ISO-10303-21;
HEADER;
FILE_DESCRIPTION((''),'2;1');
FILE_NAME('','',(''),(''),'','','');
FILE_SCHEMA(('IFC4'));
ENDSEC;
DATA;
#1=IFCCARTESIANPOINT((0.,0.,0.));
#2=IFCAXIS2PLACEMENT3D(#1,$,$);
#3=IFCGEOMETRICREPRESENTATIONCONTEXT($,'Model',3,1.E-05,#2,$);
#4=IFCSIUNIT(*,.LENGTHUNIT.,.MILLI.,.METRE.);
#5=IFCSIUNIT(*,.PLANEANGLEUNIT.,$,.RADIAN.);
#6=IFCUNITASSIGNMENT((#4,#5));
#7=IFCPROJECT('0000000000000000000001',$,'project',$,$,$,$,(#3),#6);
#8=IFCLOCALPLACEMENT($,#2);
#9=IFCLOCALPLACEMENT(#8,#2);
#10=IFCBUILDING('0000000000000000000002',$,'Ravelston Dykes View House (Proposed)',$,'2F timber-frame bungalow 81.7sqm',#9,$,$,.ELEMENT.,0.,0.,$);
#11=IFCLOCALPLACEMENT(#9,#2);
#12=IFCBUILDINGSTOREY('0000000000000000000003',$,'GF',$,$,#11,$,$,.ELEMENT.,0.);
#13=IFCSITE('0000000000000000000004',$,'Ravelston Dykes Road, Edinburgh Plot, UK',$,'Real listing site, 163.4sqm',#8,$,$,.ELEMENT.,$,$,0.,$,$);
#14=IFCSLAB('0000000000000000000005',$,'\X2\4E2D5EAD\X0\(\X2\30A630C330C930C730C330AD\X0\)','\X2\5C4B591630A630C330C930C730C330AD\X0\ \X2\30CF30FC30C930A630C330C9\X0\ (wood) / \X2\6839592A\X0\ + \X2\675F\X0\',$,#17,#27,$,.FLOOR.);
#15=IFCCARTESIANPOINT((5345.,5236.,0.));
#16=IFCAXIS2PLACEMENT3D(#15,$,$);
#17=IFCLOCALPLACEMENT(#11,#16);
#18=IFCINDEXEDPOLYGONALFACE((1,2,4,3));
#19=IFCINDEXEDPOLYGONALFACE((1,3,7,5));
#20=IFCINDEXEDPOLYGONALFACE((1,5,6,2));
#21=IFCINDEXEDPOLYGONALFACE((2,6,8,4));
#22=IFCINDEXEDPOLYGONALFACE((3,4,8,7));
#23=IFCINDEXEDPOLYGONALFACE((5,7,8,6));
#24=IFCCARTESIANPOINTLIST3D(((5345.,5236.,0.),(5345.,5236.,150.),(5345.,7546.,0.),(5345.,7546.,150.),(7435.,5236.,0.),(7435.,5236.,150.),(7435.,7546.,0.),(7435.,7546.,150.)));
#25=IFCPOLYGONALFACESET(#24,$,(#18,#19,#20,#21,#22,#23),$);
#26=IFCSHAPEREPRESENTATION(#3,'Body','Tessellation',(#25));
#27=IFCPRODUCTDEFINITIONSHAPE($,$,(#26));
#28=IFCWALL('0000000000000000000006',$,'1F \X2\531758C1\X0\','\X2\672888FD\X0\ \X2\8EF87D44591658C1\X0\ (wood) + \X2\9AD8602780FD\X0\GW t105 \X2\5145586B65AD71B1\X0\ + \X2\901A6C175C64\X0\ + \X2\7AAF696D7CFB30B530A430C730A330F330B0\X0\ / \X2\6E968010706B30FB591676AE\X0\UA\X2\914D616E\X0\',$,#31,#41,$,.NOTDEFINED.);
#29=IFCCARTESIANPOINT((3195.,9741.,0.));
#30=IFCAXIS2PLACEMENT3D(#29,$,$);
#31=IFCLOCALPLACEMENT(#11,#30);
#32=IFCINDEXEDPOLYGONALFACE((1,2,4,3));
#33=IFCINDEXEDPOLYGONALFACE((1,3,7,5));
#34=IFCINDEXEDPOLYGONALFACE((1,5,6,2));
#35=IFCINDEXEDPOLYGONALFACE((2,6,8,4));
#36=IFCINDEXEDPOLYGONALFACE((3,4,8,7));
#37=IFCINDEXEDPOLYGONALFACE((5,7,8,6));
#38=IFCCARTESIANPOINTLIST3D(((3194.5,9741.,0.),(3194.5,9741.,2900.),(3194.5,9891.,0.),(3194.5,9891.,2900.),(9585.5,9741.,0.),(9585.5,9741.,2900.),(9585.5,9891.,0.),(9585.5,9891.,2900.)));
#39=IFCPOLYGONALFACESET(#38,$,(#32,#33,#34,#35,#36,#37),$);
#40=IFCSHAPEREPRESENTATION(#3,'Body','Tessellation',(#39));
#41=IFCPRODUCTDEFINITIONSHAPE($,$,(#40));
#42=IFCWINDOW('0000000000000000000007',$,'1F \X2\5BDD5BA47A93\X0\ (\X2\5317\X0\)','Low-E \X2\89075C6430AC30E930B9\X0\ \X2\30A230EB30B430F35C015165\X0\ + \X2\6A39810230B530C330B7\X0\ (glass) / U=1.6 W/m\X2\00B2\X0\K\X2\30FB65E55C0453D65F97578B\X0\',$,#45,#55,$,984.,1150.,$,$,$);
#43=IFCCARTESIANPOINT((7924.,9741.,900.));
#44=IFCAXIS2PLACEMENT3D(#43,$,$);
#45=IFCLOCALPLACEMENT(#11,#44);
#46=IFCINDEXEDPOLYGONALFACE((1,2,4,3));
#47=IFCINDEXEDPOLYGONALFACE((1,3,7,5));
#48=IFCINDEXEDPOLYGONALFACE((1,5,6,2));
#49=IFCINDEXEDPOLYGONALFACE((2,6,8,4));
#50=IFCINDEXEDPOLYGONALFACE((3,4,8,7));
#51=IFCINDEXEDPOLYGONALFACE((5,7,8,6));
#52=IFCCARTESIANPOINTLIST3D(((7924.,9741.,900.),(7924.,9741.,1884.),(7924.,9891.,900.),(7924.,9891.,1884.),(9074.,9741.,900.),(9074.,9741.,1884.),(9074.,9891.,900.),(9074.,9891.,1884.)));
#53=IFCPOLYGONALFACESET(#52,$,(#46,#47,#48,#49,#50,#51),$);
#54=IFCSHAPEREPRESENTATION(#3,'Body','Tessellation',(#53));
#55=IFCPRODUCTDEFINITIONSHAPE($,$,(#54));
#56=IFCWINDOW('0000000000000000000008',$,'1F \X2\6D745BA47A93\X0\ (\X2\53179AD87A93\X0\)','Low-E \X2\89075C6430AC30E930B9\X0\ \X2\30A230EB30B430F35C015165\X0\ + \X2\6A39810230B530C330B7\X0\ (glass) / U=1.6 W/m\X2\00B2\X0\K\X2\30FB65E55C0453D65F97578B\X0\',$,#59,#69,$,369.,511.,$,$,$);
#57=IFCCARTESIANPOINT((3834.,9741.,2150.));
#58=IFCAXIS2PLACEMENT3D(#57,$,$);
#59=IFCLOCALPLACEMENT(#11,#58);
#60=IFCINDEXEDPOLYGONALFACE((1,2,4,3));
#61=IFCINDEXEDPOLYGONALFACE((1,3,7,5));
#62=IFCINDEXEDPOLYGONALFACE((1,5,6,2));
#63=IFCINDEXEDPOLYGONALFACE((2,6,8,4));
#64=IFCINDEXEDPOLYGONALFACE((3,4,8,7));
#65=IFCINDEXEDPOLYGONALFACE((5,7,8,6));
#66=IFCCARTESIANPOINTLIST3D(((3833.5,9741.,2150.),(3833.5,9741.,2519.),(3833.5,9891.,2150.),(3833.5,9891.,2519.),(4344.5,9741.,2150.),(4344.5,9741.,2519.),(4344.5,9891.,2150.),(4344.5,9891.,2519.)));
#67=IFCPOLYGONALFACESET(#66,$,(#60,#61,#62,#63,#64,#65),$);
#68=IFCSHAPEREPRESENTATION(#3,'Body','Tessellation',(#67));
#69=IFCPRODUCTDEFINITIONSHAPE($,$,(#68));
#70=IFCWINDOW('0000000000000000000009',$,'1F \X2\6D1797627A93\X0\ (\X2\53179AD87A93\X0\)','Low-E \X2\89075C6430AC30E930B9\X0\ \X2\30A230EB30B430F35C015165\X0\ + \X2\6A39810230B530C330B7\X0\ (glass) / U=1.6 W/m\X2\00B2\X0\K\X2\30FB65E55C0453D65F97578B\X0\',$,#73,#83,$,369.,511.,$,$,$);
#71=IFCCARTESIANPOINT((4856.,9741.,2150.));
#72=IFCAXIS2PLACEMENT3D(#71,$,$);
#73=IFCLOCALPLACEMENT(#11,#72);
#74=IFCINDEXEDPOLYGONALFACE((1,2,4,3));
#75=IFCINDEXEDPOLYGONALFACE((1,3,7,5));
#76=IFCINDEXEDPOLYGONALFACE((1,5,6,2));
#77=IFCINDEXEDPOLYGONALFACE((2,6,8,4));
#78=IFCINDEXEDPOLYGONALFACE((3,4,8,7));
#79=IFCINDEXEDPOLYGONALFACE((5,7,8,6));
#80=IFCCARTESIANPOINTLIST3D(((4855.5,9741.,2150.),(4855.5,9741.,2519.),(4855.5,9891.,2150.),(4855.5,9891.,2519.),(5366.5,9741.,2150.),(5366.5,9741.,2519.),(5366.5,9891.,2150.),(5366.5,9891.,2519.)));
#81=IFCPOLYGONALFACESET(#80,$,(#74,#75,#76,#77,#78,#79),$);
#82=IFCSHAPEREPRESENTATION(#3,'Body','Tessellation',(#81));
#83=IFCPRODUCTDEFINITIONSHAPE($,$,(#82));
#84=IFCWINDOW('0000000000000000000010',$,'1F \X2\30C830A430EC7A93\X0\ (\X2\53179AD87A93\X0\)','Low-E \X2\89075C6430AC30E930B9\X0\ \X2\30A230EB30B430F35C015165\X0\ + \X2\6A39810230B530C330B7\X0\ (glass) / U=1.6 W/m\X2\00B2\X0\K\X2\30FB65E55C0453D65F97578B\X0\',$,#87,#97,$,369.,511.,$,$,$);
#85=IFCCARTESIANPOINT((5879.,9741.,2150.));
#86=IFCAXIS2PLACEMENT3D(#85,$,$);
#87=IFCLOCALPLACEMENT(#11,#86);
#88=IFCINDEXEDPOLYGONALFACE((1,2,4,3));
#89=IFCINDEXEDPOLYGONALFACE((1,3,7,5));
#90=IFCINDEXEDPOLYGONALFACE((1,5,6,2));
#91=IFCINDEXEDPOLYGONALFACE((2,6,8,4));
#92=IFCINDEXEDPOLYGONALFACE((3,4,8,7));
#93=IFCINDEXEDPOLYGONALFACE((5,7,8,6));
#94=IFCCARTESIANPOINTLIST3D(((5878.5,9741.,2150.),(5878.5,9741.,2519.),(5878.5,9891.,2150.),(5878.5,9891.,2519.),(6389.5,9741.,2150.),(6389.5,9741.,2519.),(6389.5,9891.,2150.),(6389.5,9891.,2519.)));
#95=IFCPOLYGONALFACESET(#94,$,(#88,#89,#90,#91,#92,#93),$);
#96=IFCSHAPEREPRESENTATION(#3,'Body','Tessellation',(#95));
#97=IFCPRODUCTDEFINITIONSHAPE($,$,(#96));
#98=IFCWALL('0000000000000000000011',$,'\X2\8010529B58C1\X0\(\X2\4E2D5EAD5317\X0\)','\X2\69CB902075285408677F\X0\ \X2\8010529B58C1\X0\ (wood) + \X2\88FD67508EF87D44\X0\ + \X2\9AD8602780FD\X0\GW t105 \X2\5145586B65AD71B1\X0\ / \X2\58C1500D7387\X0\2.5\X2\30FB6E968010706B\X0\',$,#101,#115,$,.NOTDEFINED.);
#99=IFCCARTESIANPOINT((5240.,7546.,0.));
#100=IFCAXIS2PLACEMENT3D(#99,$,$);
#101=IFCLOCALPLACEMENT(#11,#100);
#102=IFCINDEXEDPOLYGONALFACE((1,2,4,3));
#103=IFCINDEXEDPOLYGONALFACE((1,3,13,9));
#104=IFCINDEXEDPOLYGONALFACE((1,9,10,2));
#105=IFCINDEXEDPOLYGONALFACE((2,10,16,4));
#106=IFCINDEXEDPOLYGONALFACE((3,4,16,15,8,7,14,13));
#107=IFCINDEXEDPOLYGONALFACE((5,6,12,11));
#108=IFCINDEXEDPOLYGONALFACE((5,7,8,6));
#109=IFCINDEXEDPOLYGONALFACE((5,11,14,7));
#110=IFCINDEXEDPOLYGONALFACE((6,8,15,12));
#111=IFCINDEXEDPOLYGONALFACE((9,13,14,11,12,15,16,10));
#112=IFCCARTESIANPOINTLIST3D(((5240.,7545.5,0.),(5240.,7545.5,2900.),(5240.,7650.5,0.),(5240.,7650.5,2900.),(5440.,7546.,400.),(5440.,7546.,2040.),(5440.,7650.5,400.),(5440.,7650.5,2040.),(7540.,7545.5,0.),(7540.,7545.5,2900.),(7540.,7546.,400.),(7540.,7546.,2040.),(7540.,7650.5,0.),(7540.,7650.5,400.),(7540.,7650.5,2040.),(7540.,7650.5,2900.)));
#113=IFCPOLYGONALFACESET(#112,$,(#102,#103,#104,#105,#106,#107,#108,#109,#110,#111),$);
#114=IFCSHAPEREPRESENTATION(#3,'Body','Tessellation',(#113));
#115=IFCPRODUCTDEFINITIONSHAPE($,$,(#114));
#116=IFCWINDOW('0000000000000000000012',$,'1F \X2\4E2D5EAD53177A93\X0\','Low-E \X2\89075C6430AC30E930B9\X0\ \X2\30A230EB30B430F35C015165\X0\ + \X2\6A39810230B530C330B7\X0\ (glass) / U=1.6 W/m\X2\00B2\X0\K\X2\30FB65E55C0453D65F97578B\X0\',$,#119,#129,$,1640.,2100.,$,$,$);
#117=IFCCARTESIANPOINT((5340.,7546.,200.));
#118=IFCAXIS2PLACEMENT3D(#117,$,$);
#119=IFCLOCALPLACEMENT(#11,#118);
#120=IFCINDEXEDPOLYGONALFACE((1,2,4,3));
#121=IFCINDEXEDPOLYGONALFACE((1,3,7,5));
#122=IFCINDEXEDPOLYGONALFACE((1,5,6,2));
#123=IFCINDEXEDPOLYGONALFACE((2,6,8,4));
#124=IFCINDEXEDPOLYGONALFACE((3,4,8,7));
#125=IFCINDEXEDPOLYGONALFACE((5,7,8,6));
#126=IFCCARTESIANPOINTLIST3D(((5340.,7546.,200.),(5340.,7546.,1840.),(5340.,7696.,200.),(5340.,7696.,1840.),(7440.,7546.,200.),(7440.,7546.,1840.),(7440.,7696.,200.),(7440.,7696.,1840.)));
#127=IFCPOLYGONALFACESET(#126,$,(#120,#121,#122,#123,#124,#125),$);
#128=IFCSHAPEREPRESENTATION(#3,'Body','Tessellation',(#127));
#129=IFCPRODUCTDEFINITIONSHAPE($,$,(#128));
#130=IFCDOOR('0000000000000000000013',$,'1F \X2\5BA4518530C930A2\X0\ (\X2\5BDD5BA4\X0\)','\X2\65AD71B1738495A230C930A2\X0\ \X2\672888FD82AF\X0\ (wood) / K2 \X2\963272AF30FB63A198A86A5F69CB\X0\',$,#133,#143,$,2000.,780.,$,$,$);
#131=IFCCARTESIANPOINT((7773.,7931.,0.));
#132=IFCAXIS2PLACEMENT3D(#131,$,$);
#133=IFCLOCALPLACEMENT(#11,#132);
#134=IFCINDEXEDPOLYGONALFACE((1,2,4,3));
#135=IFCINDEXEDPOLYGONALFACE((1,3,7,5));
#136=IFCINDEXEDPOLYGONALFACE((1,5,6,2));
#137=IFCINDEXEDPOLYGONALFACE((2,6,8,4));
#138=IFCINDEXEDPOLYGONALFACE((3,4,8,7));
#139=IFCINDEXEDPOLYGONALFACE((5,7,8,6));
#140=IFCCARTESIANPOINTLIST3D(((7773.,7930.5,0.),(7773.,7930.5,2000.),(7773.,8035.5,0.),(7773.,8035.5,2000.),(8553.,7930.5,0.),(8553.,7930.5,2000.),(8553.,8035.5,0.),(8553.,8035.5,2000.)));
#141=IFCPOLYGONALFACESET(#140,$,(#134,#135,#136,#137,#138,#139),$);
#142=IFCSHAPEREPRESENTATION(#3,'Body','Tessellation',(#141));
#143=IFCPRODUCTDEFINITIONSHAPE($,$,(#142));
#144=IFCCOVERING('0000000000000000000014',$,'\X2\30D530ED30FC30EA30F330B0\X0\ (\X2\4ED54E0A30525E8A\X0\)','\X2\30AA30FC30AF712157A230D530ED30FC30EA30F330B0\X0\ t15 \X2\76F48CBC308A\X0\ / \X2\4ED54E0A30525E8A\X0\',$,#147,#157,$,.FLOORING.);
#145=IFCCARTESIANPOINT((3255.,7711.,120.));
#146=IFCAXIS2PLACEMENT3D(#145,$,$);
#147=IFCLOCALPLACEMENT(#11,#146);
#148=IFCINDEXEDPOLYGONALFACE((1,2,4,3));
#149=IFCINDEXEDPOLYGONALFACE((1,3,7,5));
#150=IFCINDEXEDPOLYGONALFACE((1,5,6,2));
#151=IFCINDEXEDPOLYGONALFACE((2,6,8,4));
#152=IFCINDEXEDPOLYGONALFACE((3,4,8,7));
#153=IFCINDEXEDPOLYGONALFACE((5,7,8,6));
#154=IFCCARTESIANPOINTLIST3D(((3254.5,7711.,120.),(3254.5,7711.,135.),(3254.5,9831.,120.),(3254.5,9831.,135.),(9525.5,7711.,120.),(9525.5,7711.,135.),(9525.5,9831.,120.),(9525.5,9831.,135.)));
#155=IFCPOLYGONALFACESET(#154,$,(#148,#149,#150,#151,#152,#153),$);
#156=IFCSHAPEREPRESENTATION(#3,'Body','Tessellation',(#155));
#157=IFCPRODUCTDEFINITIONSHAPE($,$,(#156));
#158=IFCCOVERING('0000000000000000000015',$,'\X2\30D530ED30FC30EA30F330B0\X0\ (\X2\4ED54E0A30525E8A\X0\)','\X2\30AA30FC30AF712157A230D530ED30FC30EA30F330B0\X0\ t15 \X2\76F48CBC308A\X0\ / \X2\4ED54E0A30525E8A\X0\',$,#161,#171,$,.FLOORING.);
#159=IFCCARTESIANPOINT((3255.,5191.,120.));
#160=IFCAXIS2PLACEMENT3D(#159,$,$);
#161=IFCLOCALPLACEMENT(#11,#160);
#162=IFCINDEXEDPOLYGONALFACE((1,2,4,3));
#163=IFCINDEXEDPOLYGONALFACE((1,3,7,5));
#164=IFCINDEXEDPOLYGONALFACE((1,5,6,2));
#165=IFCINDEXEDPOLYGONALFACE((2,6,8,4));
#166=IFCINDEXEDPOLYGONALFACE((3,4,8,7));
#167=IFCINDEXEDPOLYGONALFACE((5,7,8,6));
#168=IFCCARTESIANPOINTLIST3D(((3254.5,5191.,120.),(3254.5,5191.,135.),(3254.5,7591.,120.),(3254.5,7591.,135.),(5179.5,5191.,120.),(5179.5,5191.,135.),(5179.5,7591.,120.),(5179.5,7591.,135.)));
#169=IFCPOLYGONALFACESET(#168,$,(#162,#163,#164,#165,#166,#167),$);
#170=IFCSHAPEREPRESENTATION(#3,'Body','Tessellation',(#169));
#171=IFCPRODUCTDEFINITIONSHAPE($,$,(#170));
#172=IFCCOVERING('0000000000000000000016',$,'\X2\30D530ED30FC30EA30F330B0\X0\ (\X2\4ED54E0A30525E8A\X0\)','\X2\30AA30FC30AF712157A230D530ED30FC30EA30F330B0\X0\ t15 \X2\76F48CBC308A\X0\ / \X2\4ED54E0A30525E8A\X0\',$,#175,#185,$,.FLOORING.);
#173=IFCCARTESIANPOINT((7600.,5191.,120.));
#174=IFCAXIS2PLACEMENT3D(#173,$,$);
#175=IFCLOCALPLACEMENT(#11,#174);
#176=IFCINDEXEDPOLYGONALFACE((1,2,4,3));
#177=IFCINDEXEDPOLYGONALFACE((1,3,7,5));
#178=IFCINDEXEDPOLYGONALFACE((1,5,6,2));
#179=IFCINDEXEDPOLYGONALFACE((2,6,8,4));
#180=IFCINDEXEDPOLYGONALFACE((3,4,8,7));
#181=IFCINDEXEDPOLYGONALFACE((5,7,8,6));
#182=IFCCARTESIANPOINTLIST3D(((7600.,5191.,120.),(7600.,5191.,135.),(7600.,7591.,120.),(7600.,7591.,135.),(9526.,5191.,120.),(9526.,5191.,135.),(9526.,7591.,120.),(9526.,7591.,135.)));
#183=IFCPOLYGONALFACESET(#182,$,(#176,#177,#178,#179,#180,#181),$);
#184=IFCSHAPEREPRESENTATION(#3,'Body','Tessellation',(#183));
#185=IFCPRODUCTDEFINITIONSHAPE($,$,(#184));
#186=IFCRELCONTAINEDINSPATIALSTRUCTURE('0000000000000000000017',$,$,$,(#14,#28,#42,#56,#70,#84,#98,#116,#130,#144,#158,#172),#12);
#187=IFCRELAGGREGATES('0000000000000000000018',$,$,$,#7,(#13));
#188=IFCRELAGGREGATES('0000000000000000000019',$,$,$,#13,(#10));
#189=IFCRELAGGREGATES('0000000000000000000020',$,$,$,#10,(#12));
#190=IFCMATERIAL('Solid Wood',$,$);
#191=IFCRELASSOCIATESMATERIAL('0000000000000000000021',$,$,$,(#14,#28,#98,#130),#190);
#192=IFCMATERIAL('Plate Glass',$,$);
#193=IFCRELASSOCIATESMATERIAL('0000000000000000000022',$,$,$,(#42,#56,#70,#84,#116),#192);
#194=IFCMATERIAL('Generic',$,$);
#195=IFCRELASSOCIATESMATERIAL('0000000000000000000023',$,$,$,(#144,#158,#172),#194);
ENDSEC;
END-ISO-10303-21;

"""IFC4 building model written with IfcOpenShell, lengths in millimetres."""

from ifc_helpers import new_model, si_unit, frame, frame_2d, origin, place, context, project, spatial, rectangle, extrude, material, element, fill, save


model = new_model("IFC4")

# Units and contexts
model_context = context("Model", 3, precision=1e-05, world=origin())
ifc_project = project(units=[si_unit("LENGTHUNIT", "METRE", prefix="MILLI"), si_unit("PLANEANGLEUNIT", "RADIAN")], contexts=[model_context])

# Site, building, storey
site_placement = place(None, origin())
site = spatial("IfcSite", under=ifc_project, at=site_placement, Name="Ravelston Dykes Road, Edinburgh Plot, UK", ObjectType="Real listing site, 163.4sqm", CompositionType="ELEMENT", RefElevation=0.0)
building_placement = place(site_placement, origin())
building = spatial("IfcBuilding", under=site, at=building_placement, Name="Ravelston Dykes View House (Proposed)", ObjectType="2F timber-frame bungalow 81.7sqm", CompositionType="ELEMENT", ElevationOfRefHeight=0.0, ElevationOfTerrain=0.0)
storey_placement = place(building_placement, origin())
storey = spatial("IfcBuildingStorey", under=building, at=storey_placement, Name="GF", CompositionType="ELEMENT", Elevation=0.0)

# Slab
ifc_material_1 = material(Name="Solid Wood")
slab_1_placement = place(storey_placement, frame((5345.0, 5236.0, 0.0)))
element("IfcSlab", 1, at=slab_1_placement, inside=storey, material=ifc_material_1, Name="中庭(ウッドデッキ)", Description="屋外ウッドデッキ ハードウッド (wood) / 根太 + 束", PredefinedType="FLOOR", context=model_context, shape_type="SweptSolid", body=[
    extrude(rectangle(XDim=2090.0, YDim=2310.0, at=frame_2d((1045.0, 1155.0))), frame((5345.0, 5236.0, 0.0)), (0.0, 0.0, 1.0), 150.0),
])

# Wall, openings, windows
wall_1_placement = place(storey_placement, frame((3195.0, 9741.0, 0.0)))
wall_1 = element("IfcWall", 2, at=wall_1_placement, inside=storey, material=ifc_material_1, Name="1F 北壁", Description="木製 軸組外壁 (wood) + 高性能GW t105 充填断熱 + 通気層 + 窯業系サイディング / 準耐火・外皮UA配慮", PredefinedType="NOTDEFINED", context=model_context, shape_type="SweptSolid", body=[
    extrude(rectangle(XDim=6391.0, YDim=150.0, at=frame_2d((3195.0, 75.0))), frame((3195.0, 9741.0, 0.0)), (0.0, 0.0, 1.0), 2900.0),
])
opening_1_placement = place(storey_placement, frame((7924.0, 9741.0, 900.0)))
opening_1 = element("IfcOpeningElement", 3, at=opening_1_placement, cuts=wall_1, PredefinedType="NOTDEFINED", context=model_context, shape_type="SweptSolid", body=[
    extrude(rectangle(XDim=1150.0, YDim=150.0, at=frame_2d((575.0, 75.0))), frame((7924.0, 9741.0, 900.0)), (0.0, 0.0, 1.0), 984.0),
])
opening_2_placement = place(storey_placement, frame((3834.0, 9741.0, 2150.0)))
opening_2 = element("IfcOpeningElement", 4, at=opening_2_placement, cuts=wall_1, PredefinedType="NOTDEFINED", context=model_context, shape_type="SweptSolid", body=[
    extrude(rectangle(XDim=511.0, YDim=150.0, at=frame_2d((255.0, 75.0))), frame((3834.0, 9741.0, 2150.0)), (0.0, 0.0, 1.0), 369.0),
])
opening_3_placement = place(storey_placement, frame((4856.0, 9741.0, 2150.0)))
opening_3 = element("IfcOpeningElement", 5, at=opening_3_placement, cuts=wall_1, PredefinedType="NOTDEFINED", context=model_context, shape_type="SweptSolid", body=[
    extrude(rectangle(XDim=511.0, YDim=150.0, at=frame_2d((255.0, 75.0))), frame((4856.0, 9741.0, 2150.0)), (0.0, 0.0, 1.0), 369.0),
])
opening_4_placement = place(storey_placement, frame((5879.0, 9741.0, 2150.0)))
opening_4 = element("IfcOpeningElement", 6, at=opening_4_placement, cuts=wall_1, PredefinedType="NOTDEFINED", context=model_context, shape_type="SweptSolid", body=[
    extrude(rectangle(XDim=511.0, YDim=150.0, at=frame_2d((255.0, 75.0))), frame((5879.0, 9741.0, 2150.0)), (0.0, 0.0, 1.0), 369.0),
])
ifc_material_2 = material(Name="Plate Glass")
window_1_placement = place(storey_placement, frame((7924.0, 9741.0, 900.0)))
window_1 = element("IfcWindow", 7, at=window_1_placement, inside=storey, material=ifc_material_2, Name="1F 寝室窓 (北)", Description="Low-E 複層ガラス アルゴン封入 + 樹脂サッシ (glass) / U=1.6 W/m²K・日射取得型", OverallHeight=984.0, OverallWidth=1150.0, context=model_context, shape_type="SweptSolid", body=[
    extrude(rectangle(XDim=1150.0, YDim=150.0, at=frame_2d((575.0, 75.0))), frame((7924.0, 9741.0, 900.0)), (0.0, 0.0, 1.0), 984.0),
])
fill(opening_1, window_1)
window_2_placement = place(storey_placement, frame((3834.0, 9741.0, 2150.0)))
window_2 = element("IfcWindow", 8, at=window_2_placement, inside=storey, material=ifc_material_2, Name="1F 浴室窓 (北高窓)", Description="Low-E 複層ガラス アルゴン封入 + 樹脂サッシ (glass) / U=1.6 W/m²K・日射取得型", OverallHeight=369.0, OverallWidth=511.0, context=model_context, shape_type="SweptSolid", body=[
    extrude(rectangle(XDim=511.0, YDim=150.0, at=frame_2d((255.0, 75.0))), frame((3834.0, 9741.0, 2150.0)), (0.0, 0.0, 1.0), 369.0),
])
fill(opening_2, window_2)
window_3_placement = place(storey_placement, frame((4856.0, 9741.0, 2150.0)))
window_3 = element("IfcWindow", 9, at=window_3_placement, inside=storey, material=ifc_material_2, Name="1F 洗面窓 (北高窓)", Description="Low-E 複層ガラス アルゴン封入 + 樹脂サッシ (glass) / U=1.6 W/m²K・日射取得型", OverallHeight=369.0, OverallWidth=511.0, context=model_context, shape_type="SweptSolid", body=[
    extrude(rectangle(XDim=511.0, YDim=150.0, at=frame_2d((255.0, 75.0))), frame((4856.0, 9741.0, 2150.0)), (0.0, 0.0, 1.0), 369.0),
])
fill(opening_3, window_3)
window_4_placement = place(storey_placement, frame((5879.0, 9741.0, 2150.0)))
window_4 = element("IfcWindow", 10, at=window_4_placement, inside=storey, material=ifc_material_2, Name="1F トイレ窓 (北高窓)", Description="Low-E 複層ガラス アルゴン封入 + 樹脂サッシ (glass) / U=1.6 W/m²K・日射取得型", OverallHeight=369.0, OverallWidth=511.0, context=model_context, shape_type="SweptSolid", body=[
    extrude(rectangle(XDim=511.0, YDim=150.0, at=frame_2d((255.0, 75.0))), frame((5879.0, 9741.0, 2150.0)), (0.0, 0.0, 1.0), 369.0),
])
fill(opening_4, window_4)

# Wall, opening, window
wall_2_placement = place(storey_placement, frame((5240.0, 7546.0, 0.0)))
wall_2 = element("IfcWall", 11, at=wall_2_placement, inside=storey, material=ifc_material_1, Name="耐力壁(中庭北)", Description="構造用合板 耐力壁 (wood) + 製材軸組 + 高性能GW t105 充填断熱 / 壁倍率2.5・準耐火", PredefinedType="NOTDEFINED", context=model_context, shape_type="SweptSolid", body=[
    extrude(rectangle(XDim=2300.0, YDim=105.0, at=frame_2d((1150.0, 52.0))), frame((5240.0, 7546.0, 0.0)), (0.0, 0.0, 1.0), 2900.0),
])
opening_5_placement = place(storey_placement, frame((5340.0, 7546.0, 200.0)))
opening_5 = element("IfcOpeningElement", 12, at=opening_5_placement, cuts=wall_2, PredefinedType="NOTDEFINED", context=model_context, shape_type="SweptSolid", body=[
    extrude(rectangle(XDim=2100.0, YDim=150.0, at=frame_2d((1050.0, 75.0))), frame((5340.0, 7546.0, 200.0)), (0.0, 0.0, 1.0), 1640.0),
])
window_5_placement = place(storey_placement, frame((5340.0, 7546.0, 200.0)))
window_5 = element("IfcWindow", 13, at=window_5_placement, inside=storey, material=ifc_material_2, Name="1F 中庭北窓", Description="Low-E 複層ガラス アルゴン封入 + 樹脂サッシ (glass) / U=1.6 W/m²K・日射取得型", OverallHeight=1640.0, OverallWidth=2100.0, context=model_context, shape_type="SweptSolid", body=[
    extrude(rectangle(XDim=2100.0, YDim=150.0, at=frame_2d((1050.0, 75.0))), frame((5340.0, 7546.0, 200.0)), (0.0, 0.0, 1.0), 1640.0),
])
fill(opening_5, window_5)

# Door
door_1_placement = place(storey_placement, frame((7773.0, 7931.0, 0.0)))
element("IfcDoor", 14, at=door_1_placement, inside=storey, material=ifc_material_1, Name="1F 室内ドア (寝室)", Description="断熱玄関ドア 木製芯 (wood) / K2 防犯・採風機構", OverallHeight=2000.0, OverallWidth=780.0, context=model_context, shape_type="SweptSolid", body=[
    extrude(rectangle(XDim=780.0, YDim=105.0, at=frame_2d((390.0, 52.0))), frame((7773.0, 7931.0, 0.0)), (0.0, 0.0, 1.0), 2000.0),
])

# Coverings
ifc_material_3 = material(Name="Generic")
covering_1_placement = place(storey_placement, frame((3255.0, 7711.0, 120.0)))
element("IfcCovering", 15, at=covering_1_placement, inside=storey, material=ifc_material_3, Name="フローリング (仕上げ床)", Description="オーク無垢フローリング t15 直貼り / 仕上げ床", PredefinedType="FLOORING", context=model_context, shape_type="SweptSolid", body=[
    extrude(rectangle(XDim=6271.0, YDim=2120.0, at=frame_2d((3135.0, 1060.0))), frame((3255.0, 7711.0, 120.0)), (0.0, 0.0, 1.0), 15.0),
])
covering_2_placement = place(storey_placement, frame((3255.0, 5191.0, 120.0)))
element("IfcCovering", 16, at=covering_2_placement, inside=storey, material=ifc_material_3, Name="フローリング (仕上げ床)", Description="オーク無垢フローリング t15 直貼り / 仕上げ床", PredefinedType="FLOORING", context=model_context, shape_type="SweptSolid", body=[
    extrude(rectangle(XDim=1925.0, YDim=2400.0, at=frame_2d((962.0, 1200.0))), frame((3255.0, 5191.0, 120.0)), (0.0, 0.0, 1.0), 15.0),
])
covering_3_placement = place(storey_placement, frame((7600.0, 5191.0, 120.0)))
element("IfcCovering", 17, at=covering_3_placement, inside=storey, material=ifc_material_3, Name="フローリング (仕上げ床)", Description="オーク無垢フローリング t15 直貼り / 仕上げ床", PredefinedType="FLOORING", context=model_context, shape_type="SweptSolid", body=[
    extrude(rectangle(XDim=1926.0, YDim=2400.0, at=frame_2d((963.0, 1200.0))), frame((7600.0, 5191.0, 120.0)), (0.0, 0.0, 1.0), 15.0),
])

save(model, "model.ifc")
